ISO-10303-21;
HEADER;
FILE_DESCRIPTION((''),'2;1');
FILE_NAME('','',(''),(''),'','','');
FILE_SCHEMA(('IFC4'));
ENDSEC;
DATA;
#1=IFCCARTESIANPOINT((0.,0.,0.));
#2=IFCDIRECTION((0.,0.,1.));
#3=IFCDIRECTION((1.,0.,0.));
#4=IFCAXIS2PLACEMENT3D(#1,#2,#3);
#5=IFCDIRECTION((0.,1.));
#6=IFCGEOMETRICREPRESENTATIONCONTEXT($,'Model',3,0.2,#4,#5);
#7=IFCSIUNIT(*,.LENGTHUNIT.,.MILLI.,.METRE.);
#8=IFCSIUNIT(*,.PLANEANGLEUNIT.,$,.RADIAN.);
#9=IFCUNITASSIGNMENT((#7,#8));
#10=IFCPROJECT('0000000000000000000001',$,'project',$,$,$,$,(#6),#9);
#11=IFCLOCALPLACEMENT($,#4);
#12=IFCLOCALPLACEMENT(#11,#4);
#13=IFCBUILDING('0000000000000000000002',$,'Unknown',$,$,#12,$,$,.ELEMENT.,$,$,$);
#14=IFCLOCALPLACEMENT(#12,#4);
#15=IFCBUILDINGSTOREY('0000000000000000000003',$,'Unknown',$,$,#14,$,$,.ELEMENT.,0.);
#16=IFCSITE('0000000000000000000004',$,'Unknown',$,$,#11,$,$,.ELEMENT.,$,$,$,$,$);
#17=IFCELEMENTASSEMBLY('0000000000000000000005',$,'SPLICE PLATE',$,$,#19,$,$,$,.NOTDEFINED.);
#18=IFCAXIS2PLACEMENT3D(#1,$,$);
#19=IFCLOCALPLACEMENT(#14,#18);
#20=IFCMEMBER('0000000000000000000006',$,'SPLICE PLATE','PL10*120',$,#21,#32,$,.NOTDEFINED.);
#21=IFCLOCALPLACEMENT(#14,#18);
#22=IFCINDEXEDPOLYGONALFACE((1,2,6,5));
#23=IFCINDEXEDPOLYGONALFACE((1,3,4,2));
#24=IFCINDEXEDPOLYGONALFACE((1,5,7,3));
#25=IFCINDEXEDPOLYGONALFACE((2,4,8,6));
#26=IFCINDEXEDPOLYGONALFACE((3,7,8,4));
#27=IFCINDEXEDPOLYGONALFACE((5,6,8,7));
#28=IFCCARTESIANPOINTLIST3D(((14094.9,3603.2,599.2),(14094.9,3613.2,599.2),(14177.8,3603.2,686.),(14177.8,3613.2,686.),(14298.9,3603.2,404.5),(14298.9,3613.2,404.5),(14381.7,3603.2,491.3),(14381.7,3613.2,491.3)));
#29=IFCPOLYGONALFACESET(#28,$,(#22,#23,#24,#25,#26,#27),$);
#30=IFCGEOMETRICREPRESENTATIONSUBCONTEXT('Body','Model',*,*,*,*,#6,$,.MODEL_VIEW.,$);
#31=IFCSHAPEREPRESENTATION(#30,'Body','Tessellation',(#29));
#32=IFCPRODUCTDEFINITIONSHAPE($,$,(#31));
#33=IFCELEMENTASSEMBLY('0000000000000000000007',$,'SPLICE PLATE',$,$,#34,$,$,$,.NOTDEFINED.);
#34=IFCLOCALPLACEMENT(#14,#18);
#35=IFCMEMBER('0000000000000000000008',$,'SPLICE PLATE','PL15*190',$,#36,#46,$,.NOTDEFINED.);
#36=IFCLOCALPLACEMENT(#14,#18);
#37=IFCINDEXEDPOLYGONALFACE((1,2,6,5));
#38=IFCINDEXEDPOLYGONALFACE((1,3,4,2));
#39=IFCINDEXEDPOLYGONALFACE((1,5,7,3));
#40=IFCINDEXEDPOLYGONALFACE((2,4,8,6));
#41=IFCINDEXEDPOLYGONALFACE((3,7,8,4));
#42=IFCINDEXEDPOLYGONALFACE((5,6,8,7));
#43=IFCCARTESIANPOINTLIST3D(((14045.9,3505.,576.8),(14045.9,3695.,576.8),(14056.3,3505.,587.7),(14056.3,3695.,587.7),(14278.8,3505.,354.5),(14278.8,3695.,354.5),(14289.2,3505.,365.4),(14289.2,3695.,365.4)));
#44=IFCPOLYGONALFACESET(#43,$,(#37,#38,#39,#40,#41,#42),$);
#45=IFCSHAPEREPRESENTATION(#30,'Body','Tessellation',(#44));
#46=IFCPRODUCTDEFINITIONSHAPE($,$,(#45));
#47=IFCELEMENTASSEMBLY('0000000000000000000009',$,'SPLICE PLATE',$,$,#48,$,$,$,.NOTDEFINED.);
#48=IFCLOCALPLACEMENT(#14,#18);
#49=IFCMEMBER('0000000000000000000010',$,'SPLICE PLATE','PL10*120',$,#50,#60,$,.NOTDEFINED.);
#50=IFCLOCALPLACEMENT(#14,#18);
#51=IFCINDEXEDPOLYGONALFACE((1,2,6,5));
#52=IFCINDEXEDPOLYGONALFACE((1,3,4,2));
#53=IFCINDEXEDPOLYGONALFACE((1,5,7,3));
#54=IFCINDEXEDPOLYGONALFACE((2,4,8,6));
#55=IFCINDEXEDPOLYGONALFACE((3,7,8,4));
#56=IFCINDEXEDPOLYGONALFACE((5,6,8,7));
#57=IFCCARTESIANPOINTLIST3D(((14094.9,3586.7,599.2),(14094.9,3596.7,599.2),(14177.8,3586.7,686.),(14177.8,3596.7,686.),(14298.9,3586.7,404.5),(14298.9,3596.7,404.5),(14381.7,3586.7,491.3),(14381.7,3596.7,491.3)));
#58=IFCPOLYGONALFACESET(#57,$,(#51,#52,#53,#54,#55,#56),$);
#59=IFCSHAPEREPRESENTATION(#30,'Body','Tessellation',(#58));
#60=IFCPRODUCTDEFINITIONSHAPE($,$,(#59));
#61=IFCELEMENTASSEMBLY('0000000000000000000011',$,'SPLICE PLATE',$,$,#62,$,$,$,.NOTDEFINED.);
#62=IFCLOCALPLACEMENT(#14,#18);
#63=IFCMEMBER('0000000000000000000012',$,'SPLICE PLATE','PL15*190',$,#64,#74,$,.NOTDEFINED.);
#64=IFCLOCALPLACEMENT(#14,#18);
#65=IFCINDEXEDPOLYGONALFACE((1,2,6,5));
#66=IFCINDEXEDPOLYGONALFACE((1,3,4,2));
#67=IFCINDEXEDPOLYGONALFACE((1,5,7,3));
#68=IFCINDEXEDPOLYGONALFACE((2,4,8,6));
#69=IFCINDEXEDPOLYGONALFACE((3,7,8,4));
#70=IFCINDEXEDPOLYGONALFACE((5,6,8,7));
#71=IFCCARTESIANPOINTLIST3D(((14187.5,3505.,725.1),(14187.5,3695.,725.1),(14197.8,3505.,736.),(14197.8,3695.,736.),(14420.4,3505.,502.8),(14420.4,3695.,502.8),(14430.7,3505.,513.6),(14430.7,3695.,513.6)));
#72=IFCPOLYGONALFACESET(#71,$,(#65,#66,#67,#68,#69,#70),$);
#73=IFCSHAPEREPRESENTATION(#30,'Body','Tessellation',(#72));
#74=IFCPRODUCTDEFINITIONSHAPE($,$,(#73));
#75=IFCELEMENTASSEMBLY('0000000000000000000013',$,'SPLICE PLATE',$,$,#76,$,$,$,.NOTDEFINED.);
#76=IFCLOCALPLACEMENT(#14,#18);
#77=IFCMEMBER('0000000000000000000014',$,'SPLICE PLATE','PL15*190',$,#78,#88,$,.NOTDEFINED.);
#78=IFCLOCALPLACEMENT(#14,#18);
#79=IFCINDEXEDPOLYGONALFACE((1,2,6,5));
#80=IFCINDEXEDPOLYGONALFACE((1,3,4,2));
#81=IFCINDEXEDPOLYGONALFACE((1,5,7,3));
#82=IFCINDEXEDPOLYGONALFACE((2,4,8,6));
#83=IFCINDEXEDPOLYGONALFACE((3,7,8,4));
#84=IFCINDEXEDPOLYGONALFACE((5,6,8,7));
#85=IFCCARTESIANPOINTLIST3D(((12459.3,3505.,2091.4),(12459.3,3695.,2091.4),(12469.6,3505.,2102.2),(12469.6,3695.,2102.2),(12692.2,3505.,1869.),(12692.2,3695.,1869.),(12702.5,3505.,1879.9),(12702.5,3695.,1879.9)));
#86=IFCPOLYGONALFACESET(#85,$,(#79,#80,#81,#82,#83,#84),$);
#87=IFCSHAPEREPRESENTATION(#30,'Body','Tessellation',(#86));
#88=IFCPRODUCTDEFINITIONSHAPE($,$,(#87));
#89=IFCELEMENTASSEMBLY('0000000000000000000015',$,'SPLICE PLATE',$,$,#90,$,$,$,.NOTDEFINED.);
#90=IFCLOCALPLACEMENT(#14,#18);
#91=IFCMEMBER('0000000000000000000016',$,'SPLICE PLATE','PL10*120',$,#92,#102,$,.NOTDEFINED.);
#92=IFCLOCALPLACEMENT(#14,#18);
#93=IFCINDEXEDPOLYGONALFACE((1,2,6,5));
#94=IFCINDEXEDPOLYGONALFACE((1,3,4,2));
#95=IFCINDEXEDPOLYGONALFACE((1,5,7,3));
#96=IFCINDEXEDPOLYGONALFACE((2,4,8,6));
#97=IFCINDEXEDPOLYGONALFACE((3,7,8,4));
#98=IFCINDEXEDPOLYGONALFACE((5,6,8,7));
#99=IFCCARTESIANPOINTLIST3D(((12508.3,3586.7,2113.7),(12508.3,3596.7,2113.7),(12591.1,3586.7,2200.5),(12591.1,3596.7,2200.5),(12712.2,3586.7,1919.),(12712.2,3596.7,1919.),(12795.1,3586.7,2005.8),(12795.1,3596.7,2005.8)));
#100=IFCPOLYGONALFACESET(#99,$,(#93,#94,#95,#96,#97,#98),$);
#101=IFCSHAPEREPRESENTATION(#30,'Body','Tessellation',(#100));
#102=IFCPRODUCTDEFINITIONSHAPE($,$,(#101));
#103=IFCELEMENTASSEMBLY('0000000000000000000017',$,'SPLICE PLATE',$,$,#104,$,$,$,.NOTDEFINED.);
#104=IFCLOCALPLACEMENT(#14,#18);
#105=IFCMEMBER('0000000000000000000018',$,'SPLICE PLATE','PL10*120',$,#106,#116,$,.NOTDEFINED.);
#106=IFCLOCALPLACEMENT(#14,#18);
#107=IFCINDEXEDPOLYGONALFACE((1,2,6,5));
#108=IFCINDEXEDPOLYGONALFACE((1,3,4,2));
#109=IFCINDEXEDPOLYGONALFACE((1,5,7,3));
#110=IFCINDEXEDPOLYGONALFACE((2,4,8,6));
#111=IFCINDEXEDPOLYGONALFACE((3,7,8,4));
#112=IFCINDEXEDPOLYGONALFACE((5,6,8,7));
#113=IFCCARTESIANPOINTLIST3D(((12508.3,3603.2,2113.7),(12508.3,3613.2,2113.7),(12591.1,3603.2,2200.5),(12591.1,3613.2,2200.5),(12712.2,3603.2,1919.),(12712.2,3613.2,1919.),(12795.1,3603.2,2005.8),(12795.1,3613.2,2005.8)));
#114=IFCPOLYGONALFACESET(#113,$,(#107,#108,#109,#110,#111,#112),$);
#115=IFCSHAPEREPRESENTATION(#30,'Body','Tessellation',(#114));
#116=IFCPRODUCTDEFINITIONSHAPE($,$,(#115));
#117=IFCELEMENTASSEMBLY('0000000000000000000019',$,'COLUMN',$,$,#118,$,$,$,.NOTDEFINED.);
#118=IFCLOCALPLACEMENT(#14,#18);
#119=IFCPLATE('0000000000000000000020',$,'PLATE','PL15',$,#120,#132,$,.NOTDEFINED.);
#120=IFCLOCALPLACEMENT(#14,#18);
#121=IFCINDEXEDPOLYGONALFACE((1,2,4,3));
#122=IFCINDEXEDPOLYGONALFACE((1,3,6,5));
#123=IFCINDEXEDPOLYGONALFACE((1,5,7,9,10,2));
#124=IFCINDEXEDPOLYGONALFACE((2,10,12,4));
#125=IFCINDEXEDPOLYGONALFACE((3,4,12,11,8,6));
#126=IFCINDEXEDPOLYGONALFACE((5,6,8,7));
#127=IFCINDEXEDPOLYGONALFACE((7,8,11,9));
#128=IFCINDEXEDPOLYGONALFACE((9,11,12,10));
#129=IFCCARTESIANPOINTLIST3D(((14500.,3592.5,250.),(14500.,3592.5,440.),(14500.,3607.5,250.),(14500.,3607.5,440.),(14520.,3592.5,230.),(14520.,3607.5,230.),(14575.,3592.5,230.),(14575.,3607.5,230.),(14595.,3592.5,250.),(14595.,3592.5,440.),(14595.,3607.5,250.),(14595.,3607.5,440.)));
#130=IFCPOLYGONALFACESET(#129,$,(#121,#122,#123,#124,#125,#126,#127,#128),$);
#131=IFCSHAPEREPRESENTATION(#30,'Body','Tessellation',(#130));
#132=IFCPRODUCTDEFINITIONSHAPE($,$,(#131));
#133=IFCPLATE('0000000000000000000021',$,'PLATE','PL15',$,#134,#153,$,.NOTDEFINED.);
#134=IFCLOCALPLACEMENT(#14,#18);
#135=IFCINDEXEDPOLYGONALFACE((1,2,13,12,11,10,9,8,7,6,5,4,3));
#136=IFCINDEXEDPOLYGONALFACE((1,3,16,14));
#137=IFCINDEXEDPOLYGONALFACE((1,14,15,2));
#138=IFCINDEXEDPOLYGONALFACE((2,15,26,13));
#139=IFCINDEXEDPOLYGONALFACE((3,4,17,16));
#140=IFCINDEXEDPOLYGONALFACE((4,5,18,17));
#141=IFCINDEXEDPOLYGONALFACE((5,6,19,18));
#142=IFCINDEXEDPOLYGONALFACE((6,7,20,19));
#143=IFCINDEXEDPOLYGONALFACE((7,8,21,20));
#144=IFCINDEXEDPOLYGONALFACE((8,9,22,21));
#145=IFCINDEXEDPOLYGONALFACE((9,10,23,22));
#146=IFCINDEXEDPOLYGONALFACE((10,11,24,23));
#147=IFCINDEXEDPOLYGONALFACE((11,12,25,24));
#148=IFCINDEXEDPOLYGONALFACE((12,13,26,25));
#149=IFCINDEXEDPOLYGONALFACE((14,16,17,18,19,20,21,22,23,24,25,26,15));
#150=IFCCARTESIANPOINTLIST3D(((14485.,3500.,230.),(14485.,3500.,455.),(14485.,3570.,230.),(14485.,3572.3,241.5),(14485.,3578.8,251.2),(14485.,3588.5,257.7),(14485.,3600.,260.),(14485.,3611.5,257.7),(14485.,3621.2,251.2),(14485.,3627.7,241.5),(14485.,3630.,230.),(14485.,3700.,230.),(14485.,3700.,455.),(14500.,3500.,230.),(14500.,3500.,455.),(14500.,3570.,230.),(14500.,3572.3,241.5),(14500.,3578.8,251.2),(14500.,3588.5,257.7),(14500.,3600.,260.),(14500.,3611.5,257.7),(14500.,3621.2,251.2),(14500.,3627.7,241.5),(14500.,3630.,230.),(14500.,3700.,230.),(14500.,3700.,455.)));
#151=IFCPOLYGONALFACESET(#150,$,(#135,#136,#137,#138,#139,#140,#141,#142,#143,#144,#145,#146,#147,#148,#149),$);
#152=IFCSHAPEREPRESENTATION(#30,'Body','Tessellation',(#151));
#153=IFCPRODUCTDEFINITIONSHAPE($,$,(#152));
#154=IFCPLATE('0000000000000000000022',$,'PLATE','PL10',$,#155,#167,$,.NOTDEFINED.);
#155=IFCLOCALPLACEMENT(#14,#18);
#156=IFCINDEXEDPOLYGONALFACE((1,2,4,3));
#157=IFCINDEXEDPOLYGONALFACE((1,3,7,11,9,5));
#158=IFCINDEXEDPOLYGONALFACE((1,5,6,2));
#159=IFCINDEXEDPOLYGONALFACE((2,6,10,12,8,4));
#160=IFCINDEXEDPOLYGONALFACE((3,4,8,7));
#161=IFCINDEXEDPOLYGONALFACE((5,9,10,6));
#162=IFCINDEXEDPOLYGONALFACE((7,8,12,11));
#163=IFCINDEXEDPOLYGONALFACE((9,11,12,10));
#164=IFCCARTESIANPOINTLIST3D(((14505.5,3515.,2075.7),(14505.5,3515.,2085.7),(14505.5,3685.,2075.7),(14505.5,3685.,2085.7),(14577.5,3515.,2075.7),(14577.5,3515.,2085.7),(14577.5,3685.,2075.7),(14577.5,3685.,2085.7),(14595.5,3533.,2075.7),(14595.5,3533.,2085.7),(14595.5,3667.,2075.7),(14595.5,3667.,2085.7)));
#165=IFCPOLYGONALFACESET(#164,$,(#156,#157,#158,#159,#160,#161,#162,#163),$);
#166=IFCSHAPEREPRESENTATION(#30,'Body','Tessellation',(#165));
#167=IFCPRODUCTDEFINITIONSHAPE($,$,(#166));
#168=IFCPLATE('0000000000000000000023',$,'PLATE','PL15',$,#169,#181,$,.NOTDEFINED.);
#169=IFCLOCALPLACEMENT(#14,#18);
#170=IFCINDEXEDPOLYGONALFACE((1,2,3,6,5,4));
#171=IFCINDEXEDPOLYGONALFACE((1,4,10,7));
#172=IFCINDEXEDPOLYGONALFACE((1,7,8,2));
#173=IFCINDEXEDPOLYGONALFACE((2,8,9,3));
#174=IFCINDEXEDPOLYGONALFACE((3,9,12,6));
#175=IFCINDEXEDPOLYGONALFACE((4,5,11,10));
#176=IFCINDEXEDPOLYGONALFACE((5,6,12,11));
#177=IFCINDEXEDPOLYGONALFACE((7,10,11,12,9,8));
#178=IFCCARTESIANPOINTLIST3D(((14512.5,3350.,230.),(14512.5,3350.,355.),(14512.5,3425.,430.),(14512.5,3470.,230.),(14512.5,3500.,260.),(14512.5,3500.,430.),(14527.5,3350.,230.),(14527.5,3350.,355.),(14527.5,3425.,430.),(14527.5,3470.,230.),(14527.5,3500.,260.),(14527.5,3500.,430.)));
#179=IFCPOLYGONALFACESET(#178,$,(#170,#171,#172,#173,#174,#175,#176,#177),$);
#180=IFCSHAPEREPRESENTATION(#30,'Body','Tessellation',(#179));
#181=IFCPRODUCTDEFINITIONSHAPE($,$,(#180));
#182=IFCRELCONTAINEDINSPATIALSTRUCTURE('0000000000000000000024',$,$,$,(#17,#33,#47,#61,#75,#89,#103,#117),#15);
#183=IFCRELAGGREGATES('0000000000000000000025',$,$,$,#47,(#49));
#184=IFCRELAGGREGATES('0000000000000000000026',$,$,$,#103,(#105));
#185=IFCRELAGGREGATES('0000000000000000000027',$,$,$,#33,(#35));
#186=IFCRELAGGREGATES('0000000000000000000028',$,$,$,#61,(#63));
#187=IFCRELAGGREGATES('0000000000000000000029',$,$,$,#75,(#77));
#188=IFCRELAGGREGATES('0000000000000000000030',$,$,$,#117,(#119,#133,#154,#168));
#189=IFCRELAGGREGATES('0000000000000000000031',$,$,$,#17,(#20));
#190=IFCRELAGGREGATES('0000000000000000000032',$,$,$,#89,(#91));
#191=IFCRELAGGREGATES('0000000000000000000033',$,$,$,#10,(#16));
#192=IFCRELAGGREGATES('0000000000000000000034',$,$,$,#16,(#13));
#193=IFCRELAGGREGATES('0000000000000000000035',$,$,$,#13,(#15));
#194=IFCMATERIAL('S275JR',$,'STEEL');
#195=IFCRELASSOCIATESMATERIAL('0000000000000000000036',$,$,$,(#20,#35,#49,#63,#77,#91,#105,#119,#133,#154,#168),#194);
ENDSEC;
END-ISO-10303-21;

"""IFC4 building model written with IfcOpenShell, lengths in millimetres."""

from ifc_helpers import new_model, si_unit, direction, frame, origin_with_axes, place, context, subcontext, project, spatial, line, indexed_curve, outline, extrude, material, element, aggregate, save


model = new_model("IFC4")

# Units and contexts
model_context = context("Model", 3, precision=0.2, world=origin_with_axes(), true_north=direction((0.0, 1.0)))
body_context = subcontext(model_context, "Body", "Model", "MODEL_VIEW")
ifc_project = project(units=[si_unit("LENGTHUNIT", "METRE", prefix="MILLI"), si_unit("PLANEANGLEUNIT", "RADIAN")], contexts=[model_context])

# Site, building, storey
site_placement = place(None, origin_with_axes())
site = spatial("IfcSite", under=ifc_project, at=site_placement, Name="Unknown", CompositionType="ELEMENT")
building_placement = place(site_placement, origin_with_axes())
building = spatial("IfcBuilding", under=site, at=building_placement, Name="Unknown", CompositionType="ELEMENT")
storey_placement = place(building_placement, origin_with_axes())
storey = spatial("IfcBuildingStorey", under=building, at=storey_placement, Name="Unknown", CompositionType="ELEMENT", Elevation=0.0)

# Element assemblies, members
assembly_1_placement = place(storey_placement, frame((14340.3, 3608.2, 447.9), z_axis=(0.0, 1.0, 0.0), x_axis=(-0.723355, 0.0, 0.690476)))
assembly_1 = element("IfcElementAssembly", 1, at=assembly_1_placement, inside=storey, Name="SPLICE PLATE", PredefinedType="NOTDEFINED")
ifc_material_1 = material(Name="S275JR", Category="STEEL")
member_1_placement = place(assembly_1_placement, origin_with_axes())
member_1 = element("IfcMember", 2, at=member_1_placement, material=ifc_material_1, Name="SPLICE PLATE", Description="PL10*120", PredefinedType="NOTDEFINED", context=body_context, shape_type="SolidModel", body=[
    extrude(outline(indexed_curve([(-5.0, -60.0), (5.0, -60.0), (5.0, 60.0), (-5.0, 60.0)], segments=[line(1, 2, 3, 4, 1)])), frame((0.0, 0.0, 0.0), z_axis=(-1.0, 0.0, 0.0), x_axis=(0.0, 0.0, 1.0)), (0.0, -0.000002, -1.0), 282.0),
])
assembly_2_placement = place(storey_placement, frame((14284.0, 3600.0, 359.9), z_axis=(-0.690476, 0.0, -0.723355), x_axis=(-0.723355, 0.0, 0.690476)))
assembly_2 = element("IfcElementAssembly", 3, at=assembly_2_placement, inside=storey, Name="SPLICE PLATE", PredefinedType="NOTDEFINED")
member_2_placement = place(assembly_2_placement, origin_with_axes())
member_2 = element("IfcMember", 4, at=member_2_placement, material=ifc_material_1, Name="SPLICE PLATE", Description="PL15*190", PredefinedType="NOTDEFINED", context=body_context, shape_type="SolidModel", body=[
    extrude(outline(indexed_curve([(-7.5, -95.0), (7.5, -95.0), (7.5, 95.0), (-7.5, 95.0)], segments=[line(1, 2, 3, 4, 1)])), frame((0.0, 0.0, 0.0), z_axis=(-1.0, 0.0, 0.0), x_axis=(0.0, 0.0, 1.0)), (0.0, -0.000002, -1.0), 322.0),
])
assembly_3_placement = place(storey_placement, frame((14340.3, 3591.7, 447.9), z_axis=(0.0, 1.0, 0.0), x_axis=(-0.723355, 0.0, 0.690476)))
assembly_3 = element("IfcElementAssembly", 5, at=assembly_3_placement, inside=storey, Name="SPLICE PLATE", PredefinedType="NOTDEFINED")
member_3_placement = place(assembly_3_placement, origin_with_axes())
member_3 = element("IfcMember", 6, at=member_3_placement, material=ifc_material_1, Name="SPLICE PLATE", Description="PL10*120", PredefinedType="NOTDEFINED", context=body_context, shape_type="SolidModel", body=[
    extrude(outline(indexed_curve([(-5.0, -60.0), (5.0, -60.0), (5.0, 60.0), (-5.0, 60.0)], segments=[line(1, 2, 3, 4, 1)])), frame((0.0, 0.0, 0.0), z_axis=(-1.0, 0.0, 0.0), x_axis=(0.0, 0.0, 1.0)), (0.0, -0.000002, -1.0), 282.0),
])
aggregate(assembly_3, [member_3])
assembly_4_placement = place(storey_placement, frame((14425.6, 3600.0, 508.2), z_axis=(-0.690476, 0.0, -0.723355), x_axis=(-0.723355, 0.0, 0.690476)))
assembly_4 = element("IfcElementAssembly", 7, at=assembly_4_placement, inside=storey, Name="SPLICE PLATE", PredefinedType="NOTDEFINED")
member_4_placement = place(assembly_4_placement, origin_with_axes())
member_4 = element("IfcMember", 8, at=member_4_placement, material=ifc_material_1, Name="SPLICE PLATE", Description="PL15*190", PredefinedType="NOTDEFINED", context=body_context, shape_type="SolidModel", body=[
    extrude(outline(indexed_curve([(-7.5, -95.0), (7.5, -95.0), (7.5, 95.0), (-7.5, 95.0)], segments=[line(1, 2, 3, 4, 1)])), frame((0.0, 0.0, 0.0), z_axis=(-1.0, 0.0, 0.0), x_axis=(0.0, 0.0, 1.0)), (0.0, -0.000002, -1.0), 322.0),
])
assembly_5_placement = place(storey_placement, frame((12464.4, 3600.0, 2096.8), z_axis=(-0.690476, 0.0, -0.723355), x_axis=(0.723355, 0.0, -0.690476)))
assembly_5 = element("IfcElementAssembly", 9, at=assembly_5_placement, inside=storey, Name="SPLICE PLATE", PredefinedType="NOTDEFINED")
member_5_placement = place(assembly_5_placement, origin_with_axes())
member_5 = element("IfcMember", 10, at=member_5_placement, material=ifc_material_1, Name="SPLICE PLATE", Description="PL15*190", PredefinedType="NOTDEFINED", context=body_context, shape_type="SolidModel", body=[
    extrude(outline(indexed_curve([(-7.5, -95.0), (7.5, -95.0), (7.5, 95.0), (-7.5, 95.0)], segments=[line(1, 2, 3, 4, 1)])), frame((0.0, 0.0, 0.0), z_axis=(-1.0, 0.0, 0.0), x_axis=(0.0, 0.0, 1.0)), (0.0, -0.000002, -1.0), 322.0),
])
assembly_6_placement = place(storey_placement, frame((12549.7, 3591.7, 2157.1), z_axis=(-0.000002, -1.0, 0.0), x_axis=(0.723355, 0.0, -0.690476)))
assembly_6 = element("IfcElementAssembly", 11, at=assembly_6_placement, inside=storey, Name="SPLICE PLATE", PredefinedType="NOTDEFINED")
member_6_placement = place(assembly_6_placement, origin_with_axes())
member_6 = element("IfcMember", 12, at=member_6_placement, material=ifc_material_1, Name="SPLICE PLATE", Description="PL10*120", PredefinedType="NOTDEFINED", context=body_context, shape_type="SolidModel", body=[
    extrude(outline(indexed_curve([(-5.0, -60.0), (5.0, -60.0), (5.0, 60.0), (-5.0, 60.0)], segments=[line(1, 2, 3, 4, 1)])), frame((0.0, 0.0, 0.0), z_axis=(-1.0, 0.0, 0.0), x_axis=(0.0, 0.0, 1.0)), (0.0, -0.000002, -1.0), 282.0),
])
assembly_7_placement = place(storey_placement, frame((12549.7, 3608.2, 2157.1), z_axis=(-0.000002, -1.0, 0.0), x_axis=(0.723355, 0.0, -0.690476)))
assembly_7 = element("IfcElementAssembly", 13, at=assembly_7_placement, inside=storey, Name="SPLICE PLATE", PredefinedType="NOTDEFINED")
member_7_placement = place(assembly_7_placement, origin_with_axes())
member_7 = element("IfcMember", 14, at=member_7_placement, material=ifc_material_1, Name="SPLICE PLATE", Description="PL10*120", PredefinedType="NOTDEFINED", context=body_context, shape_type="SolidModel", body=[
    extrude(outline(indexed_curve([(-5.0, -60.0), (5.0, -60.0), (5.0, 60.0), (-5.0, 60.0)], segments=[line(1, 2, 3, 4, 1)])), frame((0.0, 0.0, 0.0), z_axis=(-1.0, 0.0, 0.0), x_axis=(0.0, 0.0, 1.0)), (0.0, -0.000002, -1.0), 282.0),
])
aggregate(assembly_7, [member_7])

# Element assembly, plates, voiding feature
assembly_8_placement = place(storey_placement, frame((14600.0, 3600.0, 200.0), z_axis=(-1.0, 0.0, 0.0), x_axis=(0.0, 0.0, 1.0)))
assembly_8 = element("IfcElementAssembly", 15, at=assembly_8_placement, inside=storey, Name="COLUMN", PredefinedType="NOTDEFINED")
plate_1_placement = place(assembly_8_placement, frame((240.0, 0.0, 100.0), z_axis=(0.0, 1.0, 0.0), x_axis=(0.0, -0.000002, -1.0)))
plate_1 = element("IfcPlate", 16, at=plate_1_placement, material=ifc_material_1, Name="PLATE", Description="PL15", PredefinedType="NOTDEFINED", context=body_context, shape_type="SolidModel", body=[
    extrude(outline(indexed_curve([(0.0, 0.0), (95.0, 0.0), (95.0, 190.0), (75.0, 210.0), (20.0, 210.0), (0.0, 190.0)], segments=[line(1, 2, 3, 4, 5, 6, 1)])), frame((0.0, 0.0, 7.5), z_axis=(0.0, 0.0, 1.0), x_axis=(1.0, 0.0, 0.0)), (0.0, -0.000002, -1.0), 15.0),
])
plate_2_placement = place(assembly_8_placement, frame((30.0, 100.0, 107.5), z_axis=(0.0, -0.000002, -1.0), x_axis=(1.0, 0.0, 0.0)))
plate_2 = element("IfcPlate", 17, at=plate_2_placement, material=ifc_material_1, Name="PLATE", Description="PL15", PredefinedType="NOTDEFINED", context=body_context, shape_type="SolidModel", body=[
    extrude(outline(indexed_curve([(0.0, 0.0), (225.0, 0.0), (225.0, 200.0), (0.0, 200.0)], segments=[line(1, 2, 3, 4, 1)])), frame((0.0, 0.0, 7.5), z_axis=(0.0, 0.0, 1.0), x_axis=(1.0, 0.0, 0.0)), (0.0, -0.000002, -1.0), 15.0),
])
voiding_feature_placement = place(plate_2_placement, frame((0.0, 100.0, 27.5), z_axis=(-0.000002, -1.0, 0.0), x_axis=(0.0, -0.000002, -1.0)))
element("IfcVoidingFeature", 18, at=voiding_feature_placement, cuts=plate_2, Name="BEAM", PredefinedType="HOLE", context=body_context, shape_type="SolidModel", body=[
    extrude(outline(indexed_curve([(30.0, 0.0), (27.7, 11.5), (21.2, 21.2), (11.5, 27.7), (0.0, 30.0), (-11.5, 27.7), (-21.2, 21.2), (-27.7, 11.5), (-30.0, 0.0), (-27.7, -11.5), (-21.2, -21.2), (-11.5, -27.7), (0.0, -30.0), (11.5, -27.7), (21.2, -21.2), (27.7, -11.5)], segments=[line(1, 2, 3, 4, 5, 6, 7, 8, 9, 10, 11, 12, 13, 14, 15, 16, 1)])), frame((0.0, 0.0, 0.0), z_axis=(-1.0, 0.0, 0.0), x_axis=(0.0, 0.0, 1.0)), (0.0, -0.000002, -1.0), 120.0),
])
plate_3_placement = place(assembly_8_placement, frame((1880.7, -85.0, 94.5), z_axis=(1.0, 0.0, 0.0), x_axis=(0.0, -0.000002, -1.0)))
plate_3 = element("IfcPlate", 19, at=plate_3_placement, material=ifc_material_1, Name="PLATE", Description="PL10", PredefinedType="NOTDEFINED", context=body_context, shape_type="SolidModel", body=[
    extrude(outline(indexed_curve([(0.0, 0.0), (72.0, 0.0), (90.0, 18.0), (90.0, 152.0), (72.0, 170.0), (0.0, 170.0)], segments=[line(1, 2, 3, 4, 5, 6, 1)])), frame((0.0, 0.0, 5.0), z_axis=(0.0, 0.0, 1.0), x_axis=(1.0, 0.0, 0.0)), (0.0, -0.000002, -1.0), 10.0),
])
plate_4_placement = place(assembly_8_placement, frame((60.0, -100.0, 80.0), z_axis=(0.0, 0.0, 1.0), x_axis=(-0.707116, -0.707097, 0.0)))
plate_4 = element("IfcPlate", 20, at=plate_4_placement, material=ifc_material_1, Name="PLATE", Description="PL15", PredefinedType="NOTDEFINED", context=body_context, shape_type="SolidModel", body=[
    extrude(outline(indexed_curve([(0.0, 0.0), (42.4, 0.0), (127.3, 84.9), (38.9, 173.2), (-67.2, 173.2), (-120.2, 120.2)], segments=[line(1, 2, 3, 4, 5, 6, 1)])), frame((0.0, 0.0, 7.5), z_axis=(0.0, 0.0, 1.0), x_axis=(1.0, 0.0, 0.0)), (0.0, -0.000002, -1.0), 15.0),
])

aggregate(assembly_2, [member_2])
aggregate(assembly_4, [member_4])

aggregate(assembly_5, [member_5])
aggregate(assembly_8, [plate_1, plate_2, plate_3, plate_4])
aggregate(assembly_1, [member_1])
aggregate(assembly_6, [member_6])

save(model, "model.ifc")
